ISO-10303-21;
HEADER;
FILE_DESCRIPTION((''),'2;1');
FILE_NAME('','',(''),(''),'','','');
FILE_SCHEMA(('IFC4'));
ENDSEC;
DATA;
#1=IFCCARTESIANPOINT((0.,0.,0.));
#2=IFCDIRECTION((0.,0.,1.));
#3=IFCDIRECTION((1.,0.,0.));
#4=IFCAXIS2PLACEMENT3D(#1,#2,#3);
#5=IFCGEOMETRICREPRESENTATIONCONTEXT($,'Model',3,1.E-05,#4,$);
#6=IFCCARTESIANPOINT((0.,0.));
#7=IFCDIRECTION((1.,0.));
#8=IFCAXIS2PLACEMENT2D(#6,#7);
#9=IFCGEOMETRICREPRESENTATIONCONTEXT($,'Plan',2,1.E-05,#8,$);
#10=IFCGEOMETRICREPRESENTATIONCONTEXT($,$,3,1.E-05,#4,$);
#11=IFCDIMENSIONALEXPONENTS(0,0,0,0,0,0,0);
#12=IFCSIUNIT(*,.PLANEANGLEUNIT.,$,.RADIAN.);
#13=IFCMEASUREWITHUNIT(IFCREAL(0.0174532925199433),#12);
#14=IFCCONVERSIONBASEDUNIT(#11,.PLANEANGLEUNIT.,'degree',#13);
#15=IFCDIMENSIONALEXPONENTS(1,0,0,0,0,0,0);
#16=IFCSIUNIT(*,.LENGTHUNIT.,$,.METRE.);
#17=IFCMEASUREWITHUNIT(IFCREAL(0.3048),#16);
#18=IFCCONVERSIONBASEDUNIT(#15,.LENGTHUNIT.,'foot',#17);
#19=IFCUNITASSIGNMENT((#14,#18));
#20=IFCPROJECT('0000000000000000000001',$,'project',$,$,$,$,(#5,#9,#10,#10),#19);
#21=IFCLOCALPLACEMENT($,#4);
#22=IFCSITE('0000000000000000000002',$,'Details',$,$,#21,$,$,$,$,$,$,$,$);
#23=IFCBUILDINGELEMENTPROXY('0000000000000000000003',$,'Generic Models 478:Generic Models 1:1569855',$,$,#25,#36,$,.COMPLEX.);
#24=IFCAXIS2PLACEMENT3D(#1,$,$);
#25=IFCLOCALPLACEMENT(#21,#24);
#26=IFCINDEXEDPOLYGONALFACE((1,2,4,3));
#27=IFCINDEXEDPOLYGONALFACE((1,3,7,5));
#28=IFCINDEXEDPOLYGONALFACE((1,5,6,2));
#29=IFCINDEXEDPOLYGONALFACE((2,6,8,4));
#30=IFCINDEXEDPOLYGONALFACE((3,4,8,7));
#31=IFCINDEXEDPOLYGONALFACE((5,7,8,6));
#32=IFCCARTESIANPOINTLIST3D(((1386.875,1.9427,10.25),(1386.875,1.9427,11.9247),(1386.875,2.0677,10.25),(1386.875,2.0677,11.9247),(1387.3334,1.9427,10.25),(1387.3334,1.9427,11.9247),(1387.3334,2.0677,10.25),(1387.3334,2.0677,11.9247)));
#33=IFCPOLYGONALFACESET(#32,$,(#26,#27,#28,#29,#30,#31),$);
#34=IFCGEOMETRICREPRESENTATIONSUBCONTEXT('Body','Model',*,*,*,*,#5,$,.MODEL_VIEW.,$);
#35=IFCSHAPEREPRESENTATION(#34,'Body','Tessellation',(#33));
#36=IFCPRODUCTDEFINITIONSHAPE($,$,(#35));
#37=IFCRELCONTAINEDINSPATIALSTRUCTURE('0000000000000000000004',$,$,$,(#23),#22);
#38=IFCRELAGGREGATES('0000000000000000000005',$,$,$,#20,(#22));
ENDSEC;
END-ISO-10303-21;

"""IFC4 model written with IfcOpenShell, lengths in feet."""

from ifc_helpers import new_model, entity, si_unit, converted_unit, frame, origin_with_axes, origin_2d_with_axis, place, context, subcontext, project, spatial, polyline, outline, extrude, element, save


model = new_model("IFC4")

# Units and contexts
model_context = context("Model", 3, precision=1e-05, world=origin_with_axes())
plan_context = context("Plan", 2, precision=1e-05, world=origin_2d_with_axis())
context_of_model = context(None, 3, precision=1e-05, world=origin_with_axes())
body_context = subcontext(model_context, "Body", "Model", "MODEL_VIEW")
ifc_project = project(units=[converted_unit("PLANEANGLEUNIT", "degree", entity("IfcReal", 0.0174532925199433), si_unit("PLANEANGLEUNIT", "RADIAN"), dimensions=[0, 0, 0, 0, 0, 0, 0]), converted_unit("LENGTHUNIT", "foot", entity("IfcReal", 0.3048), si_unit("LENGTHUNIT", "METRE"), dimensions=[1, 0, 0, 0, 0, 0, 0])], contexts=[model_context, plan_context, context_of_model, context_of_model])

# Site
site_placement = place(None, origin_with_axes())
site = spatial("IfcSite", under=ifc_project, at=site_placement, Name="Details")

# Building element proxy
proxy_1_placement = place(site_placement, frame((1386.875, 5.9427, 10.25), z_axis=(0.0, -1.0, 0.0), x_axis=(1.0, 0.0, 0.0)))
element("IfcBuildingElementProxy", 1, at=proxy_1_placement, inside=site, Name="Generic Models 478:Generic Models 1:1569855", PredefinedType="COMPLEX", context=body_context, shape_type="SweptSolid", body=[
    extrude(outline(polyline([(-0.8373, -0.2292), (0.8373, -0.2292), (0.8373, 0.2292), (-0.8373, 0.2292), (-0.8373, -0.2292)])), frame((0.2292, 0.8373, 3.875), z_axis=(0.0, 0.0, -1.0), x_axis=(0.0, 1.0, 0.0)), (0.0, 0.0, -1.0), 0.125),
])

save(model, "model.ifc")
